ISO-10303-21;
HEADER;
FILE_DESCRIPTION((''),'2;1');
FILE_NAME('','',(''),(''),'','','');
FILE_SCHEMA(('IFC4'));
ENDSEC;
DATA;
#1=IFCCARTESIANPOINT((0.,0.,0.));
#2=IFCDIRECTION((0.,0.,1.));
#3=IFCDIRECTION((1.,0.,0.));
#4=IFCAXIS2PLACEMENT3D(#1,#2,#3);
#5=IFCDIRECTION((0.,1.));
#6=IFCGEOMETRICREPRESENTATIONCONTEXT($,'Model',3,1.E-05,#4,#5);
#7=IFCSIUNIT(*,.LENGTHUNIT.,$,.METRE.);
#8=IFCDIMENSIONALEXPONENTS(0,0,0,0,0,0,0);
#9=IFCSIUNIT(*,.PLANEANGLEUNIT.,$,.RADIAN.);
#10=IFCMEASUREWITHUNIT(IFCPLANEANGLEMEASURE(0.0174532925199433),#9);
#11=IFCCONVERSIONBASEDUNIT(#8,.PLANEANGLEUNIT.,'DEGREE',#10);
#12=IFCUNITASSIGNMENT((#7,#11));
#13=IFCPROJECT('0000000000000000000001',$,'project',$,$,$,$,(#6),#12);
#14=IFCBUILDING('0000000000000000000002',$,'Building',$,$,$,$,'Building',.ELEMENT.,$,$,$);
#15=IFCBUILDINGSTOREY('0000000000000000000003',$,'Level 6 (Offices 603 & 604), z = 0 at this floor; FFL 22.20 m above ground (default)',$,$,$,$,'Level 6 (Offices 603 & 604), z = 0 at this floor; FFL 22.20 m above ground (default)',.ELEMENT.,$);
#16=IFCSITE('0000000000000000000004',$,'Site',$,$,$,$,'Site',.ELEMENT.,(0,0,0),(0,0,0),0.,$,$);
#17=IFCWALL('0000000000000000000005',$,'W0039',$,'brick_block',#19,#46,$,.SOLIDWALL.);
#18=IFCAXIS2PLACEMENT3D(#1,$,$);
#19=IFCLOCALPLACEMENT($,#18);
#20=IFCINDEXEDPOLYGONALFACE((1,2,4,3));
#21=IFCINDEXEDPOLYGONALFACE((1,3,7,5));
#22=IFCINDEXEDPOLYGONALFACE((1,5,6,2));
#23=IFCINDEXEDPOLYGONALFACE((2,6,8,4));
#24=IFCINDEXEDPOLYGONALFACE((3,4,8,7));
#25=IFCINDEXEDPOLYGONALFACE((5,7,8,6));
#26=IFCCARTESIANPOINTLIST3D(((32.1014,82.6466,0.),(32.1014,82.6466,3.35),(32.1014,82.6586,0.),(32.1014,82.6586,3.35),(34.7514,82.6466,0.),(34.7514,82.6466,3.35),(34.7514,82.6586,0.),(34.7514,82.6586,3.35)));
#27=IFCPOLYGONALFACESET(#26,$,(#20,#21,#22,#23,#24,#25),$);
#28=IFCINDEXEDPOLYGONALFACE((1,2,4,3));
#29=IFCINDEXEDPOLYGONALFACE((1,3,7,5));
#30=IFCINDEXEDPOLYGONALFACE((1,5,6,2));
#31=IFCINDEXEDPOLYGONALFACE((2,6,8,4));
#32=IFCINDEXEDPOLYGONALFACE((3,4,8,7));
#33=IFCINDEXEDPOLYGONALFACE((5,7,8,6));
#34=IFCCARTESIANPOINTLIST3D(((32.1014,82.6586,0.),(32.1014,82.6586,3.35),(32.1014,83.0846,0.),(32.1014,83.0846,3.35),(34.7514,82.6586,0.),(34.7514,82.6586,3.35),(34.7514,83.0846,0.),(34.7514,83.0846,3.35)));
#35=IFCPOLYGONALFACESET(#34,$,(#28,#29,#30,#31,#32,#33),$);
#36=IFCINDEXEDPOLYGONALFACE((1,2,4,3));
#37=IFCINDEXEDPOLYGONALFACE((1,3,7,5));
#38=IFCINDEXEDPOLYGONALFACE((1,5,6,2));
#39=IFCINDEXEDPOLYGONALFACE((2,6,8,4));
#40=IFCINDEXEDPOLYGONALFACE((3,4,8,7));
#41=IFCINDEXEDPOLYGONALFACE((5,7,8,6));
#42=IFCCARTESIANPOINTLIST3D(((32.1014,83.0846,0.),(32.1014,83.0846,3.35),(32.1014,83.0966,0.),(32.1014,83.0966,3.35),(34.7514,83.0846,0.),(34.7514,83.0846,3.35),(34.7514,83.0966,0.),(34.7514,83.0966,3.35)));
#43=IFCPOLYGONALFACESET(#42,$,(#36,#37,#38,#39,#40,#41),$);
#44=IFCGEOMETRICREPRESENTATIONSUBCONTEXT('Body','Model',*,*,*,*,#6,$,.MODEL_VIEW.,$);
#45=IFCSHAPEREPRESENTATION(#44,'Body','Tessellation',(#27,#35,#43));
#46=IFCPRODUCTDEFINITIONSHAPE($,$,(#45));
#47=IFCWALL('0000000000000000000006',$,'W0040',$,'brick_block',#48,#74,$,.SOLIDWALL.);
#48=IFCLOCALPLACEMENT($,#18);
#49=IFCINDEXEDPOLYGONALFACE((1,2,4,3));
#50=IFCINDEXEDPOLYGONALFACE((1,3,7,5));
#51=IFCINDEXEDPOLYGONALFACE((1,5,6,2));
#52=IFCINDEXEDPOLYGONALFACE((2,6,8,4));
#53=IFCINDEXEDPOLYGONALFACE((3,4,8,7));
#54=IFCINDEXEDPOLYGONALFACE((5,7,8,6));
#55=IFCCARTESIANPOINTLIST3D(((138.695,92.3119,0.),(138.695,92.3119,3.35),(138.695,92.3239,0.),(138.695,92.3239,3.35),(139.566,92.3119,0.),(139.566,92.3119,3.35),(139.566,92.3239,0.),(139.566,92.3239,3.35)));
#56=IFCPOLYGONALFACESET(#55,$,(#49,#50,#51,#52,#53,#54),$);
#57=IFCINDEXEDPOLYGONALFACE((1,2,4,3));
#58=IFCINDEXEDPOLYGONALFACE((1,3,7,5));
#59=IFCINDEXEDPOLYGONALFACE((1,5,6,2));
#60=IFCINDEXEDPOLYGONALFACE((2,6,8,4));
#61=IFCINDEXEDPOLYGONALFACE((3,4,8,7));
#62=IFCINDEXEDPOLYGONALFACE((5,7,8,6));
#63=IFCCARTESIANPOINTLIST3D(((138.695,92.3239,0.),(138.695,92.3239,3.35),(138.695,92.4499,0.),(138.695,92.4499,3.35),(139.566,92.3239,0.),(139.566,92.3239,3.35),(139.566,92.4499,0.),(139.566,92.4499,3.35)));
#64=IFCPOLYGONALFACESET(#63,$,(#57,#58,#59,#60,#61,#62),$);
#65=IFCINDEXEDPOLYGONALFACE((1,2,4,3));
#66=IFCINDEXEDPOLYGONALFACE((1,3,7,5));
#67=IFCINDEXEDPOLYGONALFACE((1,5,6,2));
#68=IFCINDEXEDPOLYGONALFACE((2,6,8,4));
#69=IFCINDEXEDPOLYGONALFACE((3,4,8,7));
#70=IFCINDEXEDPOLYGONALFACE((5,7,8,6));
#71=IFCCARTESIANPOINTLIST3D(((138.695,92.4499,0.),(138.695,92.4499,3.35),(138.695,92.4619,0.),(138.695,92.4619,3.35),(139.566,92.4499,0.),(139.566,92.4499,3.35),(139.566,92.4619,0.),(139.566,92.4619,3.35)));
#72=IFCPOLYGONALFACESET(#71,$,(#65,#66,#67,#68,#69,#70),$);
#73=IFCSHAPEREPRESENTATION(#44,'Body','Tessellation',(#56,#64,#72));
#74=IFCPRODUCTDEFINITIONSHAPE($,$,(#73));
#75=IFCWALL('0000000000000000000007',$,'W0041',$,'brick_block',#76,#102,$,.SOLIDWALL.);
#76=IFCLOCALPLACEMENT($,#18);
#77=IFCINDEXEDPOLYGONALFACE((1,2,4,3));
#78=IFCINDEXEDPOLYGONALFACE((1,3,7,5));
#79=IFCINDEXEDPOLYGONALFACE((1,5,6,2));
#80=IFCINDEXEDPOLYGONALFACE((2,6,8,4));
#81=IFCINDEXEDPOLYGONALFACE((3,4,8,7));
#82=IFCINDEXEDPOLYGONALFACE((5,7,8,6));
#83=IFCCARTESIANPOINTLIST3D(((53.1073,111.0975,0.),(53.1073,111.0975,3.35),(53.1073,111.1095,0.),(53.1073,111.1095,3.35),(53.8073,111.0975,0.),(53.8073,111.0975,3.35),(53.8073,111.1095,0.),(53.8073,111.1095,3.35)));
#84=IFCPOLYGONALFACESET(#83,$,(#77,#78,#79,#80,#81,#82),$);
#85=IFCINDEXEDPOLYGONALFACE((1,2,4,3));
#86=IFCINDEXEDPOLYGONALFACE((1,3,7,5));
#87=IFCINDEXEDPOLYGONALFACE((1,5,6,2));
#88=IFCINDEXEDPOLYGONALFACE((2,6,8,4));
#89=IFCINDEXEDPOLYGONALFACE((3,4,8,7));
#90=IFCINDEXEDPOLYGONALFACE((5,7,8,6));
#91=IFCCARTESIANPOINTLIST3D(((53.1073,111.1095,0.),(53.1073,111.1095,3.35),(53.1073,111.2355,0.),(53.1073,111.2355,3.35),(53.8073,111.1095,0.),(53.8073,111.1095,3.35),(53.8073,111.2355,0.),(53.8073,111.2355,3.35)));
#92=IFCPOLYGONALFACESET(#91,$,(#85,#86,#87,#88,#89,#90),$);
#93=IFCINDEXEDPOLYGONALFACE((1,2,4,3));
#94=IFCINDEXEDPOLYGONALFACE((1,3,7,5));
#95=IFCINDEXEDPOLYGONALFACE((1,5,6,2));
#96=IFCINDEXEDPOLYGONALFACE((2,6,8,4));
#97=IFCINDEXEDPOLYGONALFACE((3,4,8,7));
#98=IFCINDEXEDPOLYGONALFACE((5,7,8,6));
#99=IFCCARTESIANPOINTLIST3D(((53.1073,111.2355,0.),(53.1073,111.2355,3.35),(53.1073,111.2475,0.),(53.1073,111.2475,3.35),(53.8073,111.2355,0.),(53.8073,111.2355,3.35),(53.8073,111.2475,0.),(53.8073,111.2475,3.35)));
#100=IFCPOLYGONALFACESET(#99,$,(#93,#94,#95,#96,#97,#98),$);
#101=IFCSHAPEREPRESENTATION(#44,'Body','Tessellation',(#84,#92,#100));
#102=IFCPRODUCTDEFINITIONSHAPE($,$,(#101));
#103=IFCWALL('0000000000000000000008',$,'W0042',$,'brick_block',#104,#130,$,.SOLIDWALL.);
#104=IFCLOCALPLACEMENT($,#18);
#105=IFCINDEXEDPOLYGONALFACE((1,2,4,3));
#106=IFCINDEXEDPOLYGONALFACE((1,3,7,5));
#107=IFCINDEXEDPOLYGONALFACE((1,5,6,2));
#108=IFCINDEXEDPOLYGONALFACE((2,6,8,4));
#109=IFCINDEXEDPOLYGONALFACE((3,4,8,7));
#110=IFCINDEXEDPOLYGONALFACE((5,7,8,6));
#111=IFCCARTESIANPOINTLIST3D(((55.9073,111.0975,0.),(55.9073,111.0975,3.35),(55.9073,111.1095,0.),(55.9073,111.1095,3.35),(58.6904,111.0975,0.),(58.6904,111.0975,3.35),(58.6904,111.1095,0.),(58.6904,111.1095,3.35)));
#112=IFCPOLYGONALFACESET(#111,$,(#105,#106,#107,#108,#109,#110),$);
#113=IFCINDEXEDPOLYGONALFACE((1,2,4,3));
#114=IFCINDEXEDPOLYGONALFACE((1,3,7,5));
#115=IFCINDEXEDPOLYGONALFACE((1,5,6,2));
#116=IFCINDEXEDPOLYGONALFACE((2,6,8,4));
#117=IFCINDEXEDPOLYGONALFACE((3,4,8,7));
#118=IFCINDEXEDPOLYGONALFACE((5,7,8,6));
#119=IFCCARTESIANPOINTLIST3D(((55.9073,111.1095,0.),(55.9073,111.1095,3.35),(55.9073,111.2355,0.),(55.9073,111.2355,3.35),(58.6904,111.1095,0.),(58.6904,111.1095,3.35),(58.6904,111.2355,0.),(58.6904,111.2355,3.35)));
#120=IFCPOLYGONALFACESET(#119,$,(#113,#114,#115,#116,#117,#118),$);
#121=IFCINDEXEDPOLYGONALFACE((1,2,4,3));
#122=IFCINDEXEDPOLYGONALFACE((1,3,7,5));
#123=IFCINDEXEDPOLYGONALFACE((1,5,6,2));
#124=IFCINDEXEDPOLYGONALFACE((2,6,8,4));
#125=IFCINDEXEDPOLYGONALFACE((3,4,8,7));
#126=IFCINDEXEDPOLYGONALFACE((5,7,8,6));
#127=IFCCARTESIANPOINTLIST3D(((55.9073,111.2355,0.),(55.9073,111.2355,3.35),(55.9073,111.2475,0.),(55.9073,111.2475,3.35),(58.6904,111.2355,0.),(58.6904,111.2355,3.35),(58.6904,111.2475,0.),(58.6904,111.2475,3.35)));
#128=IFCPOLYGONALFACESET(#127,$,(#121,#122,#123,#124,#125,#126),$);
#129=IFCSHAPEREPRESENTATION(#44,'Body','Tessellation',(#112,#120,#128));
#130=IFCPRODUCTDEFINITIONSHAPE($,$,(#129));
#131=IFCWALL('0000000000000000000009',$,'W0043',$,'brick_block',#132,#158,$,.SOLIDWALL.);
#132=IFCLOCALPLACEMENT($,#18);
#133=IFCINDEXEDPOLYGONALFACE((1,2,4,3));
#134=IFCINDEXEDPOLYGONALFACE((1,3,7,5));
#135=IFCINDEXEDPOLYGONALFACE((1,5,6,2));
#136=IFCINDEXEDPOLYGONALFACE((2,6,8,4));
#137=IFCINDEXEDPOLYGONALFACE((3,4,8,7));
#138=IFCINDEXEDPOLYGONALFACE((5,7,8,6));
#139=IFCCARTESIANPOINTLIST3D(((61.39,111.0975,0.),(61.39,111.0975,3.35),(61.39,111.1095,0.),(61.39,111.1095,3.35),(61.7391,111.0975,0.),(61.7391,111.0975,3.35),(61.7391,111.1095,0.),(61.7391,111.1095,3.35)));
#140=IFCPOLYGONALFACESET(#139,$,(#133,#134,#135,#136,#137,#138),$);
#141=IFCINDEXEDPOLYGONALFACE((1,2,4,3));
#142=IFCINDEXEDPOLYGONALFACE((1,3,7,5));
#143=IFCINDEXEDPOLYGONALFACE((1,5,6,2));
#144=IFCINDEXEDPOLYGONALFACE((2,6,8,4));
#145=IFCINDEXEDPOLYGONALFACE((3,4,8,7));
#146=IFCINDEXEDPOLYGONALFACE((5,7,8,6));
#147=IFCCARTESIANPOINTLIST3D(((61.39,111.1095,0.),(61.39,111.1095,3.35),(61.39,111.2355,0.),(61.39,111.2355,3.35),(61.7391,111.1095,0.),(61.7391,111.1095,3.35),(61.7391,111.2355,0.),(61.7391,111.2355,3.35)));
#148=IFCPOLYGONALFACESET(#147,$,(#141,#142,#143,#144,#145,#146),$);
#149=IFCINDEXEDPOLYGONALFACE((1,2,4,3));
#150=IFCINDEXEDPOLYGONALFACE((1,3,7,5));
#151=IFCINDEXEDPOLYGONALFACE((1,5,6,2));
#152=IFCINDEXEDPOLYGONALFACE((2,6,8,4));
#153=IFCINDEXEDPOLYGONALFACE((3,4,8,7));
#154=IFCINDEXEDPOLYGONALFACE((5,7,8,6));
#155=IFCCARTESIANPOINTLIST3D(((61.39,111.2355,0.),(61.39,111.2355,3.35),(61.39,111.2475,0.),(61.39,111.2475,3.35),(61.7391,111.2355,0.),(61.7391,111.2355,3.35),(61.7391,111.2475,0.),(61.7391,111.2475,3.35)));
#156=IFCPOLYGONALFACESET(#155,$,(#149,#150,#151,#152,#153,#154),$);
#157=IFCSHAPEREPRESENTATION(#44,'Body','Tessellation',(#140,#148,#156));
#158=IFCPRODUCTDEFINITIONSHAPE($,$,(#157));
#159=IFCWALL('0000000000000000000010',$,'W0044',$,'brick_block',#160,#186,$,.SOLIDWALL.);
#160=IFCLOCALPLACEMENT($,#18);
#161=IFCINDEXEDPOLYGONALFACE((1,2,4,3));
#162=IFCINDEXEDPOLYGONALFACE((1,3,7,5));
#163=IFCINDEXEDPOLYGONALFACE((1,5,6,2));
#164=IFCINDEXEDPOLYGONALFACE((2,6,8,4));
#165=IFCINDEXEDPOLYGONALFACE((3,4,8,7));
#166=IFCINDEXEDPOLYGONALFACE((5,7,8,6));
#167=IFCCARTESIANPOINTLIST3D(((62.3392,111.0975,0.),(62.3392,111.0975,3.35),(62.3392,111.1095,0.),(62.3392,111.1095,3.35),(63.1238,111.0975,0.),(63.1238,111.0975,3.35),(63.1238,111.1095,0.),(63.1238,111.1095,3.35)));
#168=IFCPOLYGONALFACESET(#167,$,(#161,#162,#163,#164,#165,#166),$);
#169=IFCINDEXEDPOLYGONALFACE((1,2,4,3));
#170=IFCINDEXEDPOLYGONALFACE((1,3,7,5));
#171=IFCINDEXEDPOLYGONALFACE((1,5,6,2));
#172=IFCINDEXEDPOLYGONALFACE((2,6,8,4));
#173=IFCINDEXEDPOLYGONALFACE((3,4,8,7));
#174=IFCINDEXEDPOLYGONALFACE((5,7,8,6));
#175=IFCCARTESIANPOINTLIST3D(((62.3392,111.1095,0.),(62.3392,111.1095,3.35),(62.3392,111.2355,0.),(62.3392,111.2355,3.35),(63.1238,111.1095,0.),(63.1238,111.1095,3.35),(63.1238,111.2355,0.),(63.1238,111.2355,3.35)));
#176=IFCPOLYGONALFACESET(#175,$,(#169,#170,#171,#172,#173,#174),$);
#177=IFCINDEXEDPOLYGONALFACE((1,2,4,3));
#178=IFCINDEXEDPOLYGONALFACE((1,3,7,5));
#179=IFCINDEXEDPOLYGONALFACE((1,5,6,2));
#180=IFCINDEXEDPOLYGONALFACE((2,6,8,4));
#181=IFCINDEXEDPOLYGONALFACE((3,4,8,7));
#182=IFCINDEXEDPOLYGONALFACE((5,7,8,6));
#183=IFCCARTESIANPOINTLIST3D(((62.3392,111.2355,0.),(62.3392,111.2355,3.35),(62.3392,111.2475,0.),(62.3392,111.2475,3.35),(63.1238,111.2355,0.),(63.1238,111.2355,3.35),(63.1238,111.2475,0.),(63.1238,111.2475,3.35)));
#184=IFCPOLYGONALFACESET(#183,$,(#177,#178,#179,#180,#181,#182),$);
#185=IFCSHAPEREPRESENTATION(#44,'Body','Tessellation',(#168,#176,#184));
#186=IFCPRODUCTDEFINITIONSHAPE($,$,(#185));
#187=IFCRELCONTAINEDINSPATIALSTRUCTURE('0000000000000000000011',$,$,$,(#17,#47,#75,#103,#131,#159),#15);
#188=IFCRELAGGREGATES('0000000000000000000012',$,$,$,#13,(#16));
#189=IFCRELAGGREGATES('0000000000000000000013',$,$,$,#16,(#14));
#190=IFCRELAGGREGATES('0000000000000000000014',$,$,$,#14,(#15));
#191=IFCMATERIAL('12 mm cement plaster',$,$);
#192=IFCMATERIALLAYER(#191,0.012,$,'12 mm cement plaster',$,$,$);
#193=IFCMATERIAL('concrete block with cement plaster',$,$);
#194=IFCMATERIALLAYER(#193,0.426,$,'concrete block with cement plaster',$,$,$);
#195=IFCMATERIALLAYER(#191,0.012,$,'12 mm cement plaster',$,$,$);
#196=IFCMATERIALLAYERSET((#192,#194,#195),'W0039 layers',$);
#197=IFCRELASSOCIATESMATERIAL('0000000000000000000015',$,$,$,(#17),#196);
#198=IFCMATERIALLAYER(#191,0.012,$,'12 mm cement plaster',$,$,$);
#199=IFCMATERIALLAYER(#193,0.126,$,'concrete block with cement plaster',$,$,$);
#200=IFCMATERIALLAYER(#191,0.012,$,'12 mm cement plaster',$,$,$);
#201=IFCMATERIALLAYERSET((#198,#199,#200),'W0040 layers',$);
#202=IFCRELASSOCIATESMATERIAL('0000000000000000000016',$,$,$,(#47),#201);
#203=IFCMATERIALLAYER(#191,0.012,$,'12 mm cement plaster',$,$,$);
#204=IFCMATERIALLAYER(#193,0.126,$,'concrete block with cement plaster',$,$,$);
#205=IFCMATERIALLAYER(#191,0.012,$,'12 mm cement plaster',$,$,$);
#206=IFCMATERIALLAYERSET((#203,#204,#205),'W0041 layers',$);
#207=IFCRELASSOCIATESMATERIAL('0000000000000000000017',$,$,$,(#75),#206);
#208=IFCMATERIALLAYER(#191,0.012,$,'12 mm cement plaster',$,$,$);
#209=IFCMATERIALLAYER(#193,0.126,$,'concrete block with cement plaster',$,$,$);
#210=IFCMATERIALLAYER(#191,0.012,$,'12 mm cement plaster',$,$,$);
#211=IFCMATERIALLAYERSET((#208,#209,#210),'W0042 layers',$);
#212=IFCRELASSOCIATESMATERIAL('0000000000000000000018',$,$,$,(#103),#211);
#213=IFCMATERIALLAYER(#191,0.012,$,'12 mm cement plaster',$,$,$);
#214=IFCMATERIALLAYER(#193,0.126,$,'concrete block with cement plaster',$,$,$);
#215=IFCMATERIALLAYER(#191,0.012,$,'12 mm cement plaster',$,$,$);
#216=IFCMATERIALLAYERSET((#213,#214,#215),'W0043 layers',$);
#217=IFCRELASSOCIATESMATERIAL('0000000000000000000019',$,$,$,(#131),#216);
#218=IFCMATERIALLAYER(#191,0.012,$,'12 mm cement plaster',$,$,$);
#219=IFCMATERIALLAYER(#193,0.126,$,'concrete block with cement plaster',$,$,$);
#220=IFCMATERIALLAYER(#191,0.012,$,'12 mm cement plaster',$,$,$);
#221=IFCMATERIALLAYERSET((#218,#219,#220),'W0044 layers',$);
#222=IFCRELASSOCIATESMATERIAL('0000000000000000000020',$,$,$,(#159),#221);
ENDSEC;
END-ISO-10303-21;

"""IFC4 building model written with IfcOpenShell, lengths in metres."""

from ifc_helpers import new_model, entity, si_unit, converted_unit, direction, frame, frame_2d, origin_with_axes, origin_2d_with_axis, place, context, subcontext, project, spatial, rectangle, extrude, material, layer, layer_set, layer_usage, element, save


model = new_model("IFC4")

# Units and contexts
model_context = context("Model", 3, precision=1e-05, world=origin_with_axes(), true_north=direction((0.0, 1.0)))
body_context = subcontext(model_context, "Body", "Model", "MODEL_VIEW")
ifc_project = project(units=[si_unit("LENGTHUNIT", "METRE"), converted_unit("PLANEANGLEUNIT", "DEGREE", entity("IfcPlaneAngleMeasure", 0.0174532925199433), si_unit("PLANEANGLEUNIT", "RADIAN"), dimensions=[0, 0, 0, 0, 0, 0, 0])], contexts=[model_context])

# Site, building, storey
site = spatial("IfcSite", under=ifc_project, Name="Site", LongName="Site", CompositionType="ELEMENT", RefLatitude=(0, 0, 0), RefLongitude=(0, 0, 0), RefElevation=0.0)
building = spatial("IfcBuilding", under=site, Name="Building", LongName="Building", CompositionType="ELEMENT")
storey = spatial("IfcBuildingStorey", under=building, Name="Level 6 (Offices 603 & 604), z = 0 at this floor; FFL 22.20 m above ground (default)", LongName="Level 6 (Offices 603 & 604), z = 0 at this floor; FFL 22.20 m above ground (default)", CompositionType="ELEMENT")

# Shared definitions
ifc_material_1 = material(Name="12 mm cement plaster")
ifc_material_2 = material(Name="concrete block with cement plaster")
placement = place(None, origin_with_axes())

# Walls
ifc_layer_1 = layer(ifc_material_1, 0.012, Name="12 mm cement plaster")
ifc_layer_2 = layer(ifc_material_2, 0.426, Name="concrete block with cement plaster")
ifc_layer_3 = layer(ifc_material_1, 0.012, Name="12 mm cement plaster")
ifc_layer_set_1 = layer_set([ifc_layer_1, ifc_layer_2, ifc_layer_3], Name="W0039 layers")
ifc_layer_usage_1 = layer_usage(ifc_layer_set_1, "AXIS2", "POSITIVE", -0.225)
element("IfcWall", 1, at=placement, inside=storey, material=ifc_layer_usage_1, Name="W0039", ObjectType="brick_block", PredefinedType="SOLIDWALL", context=body_context, shape_type="SweptSolid", body=[
    extrude(rectangle(XDim=2.65, YDim=0.012, at=origin_2d_with_axis()), frame((33.4264, 82.6526, 0.0), z_axis=(0.0, 0.0, 1.0), x_axis=(1.0, 0.0, 0.0)), (0.0, 0.0, 1.0), 3.35),
    extrude(rectangle(XDim=2.65, YDim=0.426, at=frame_2d((0.0, 0.219), x_axis=(1.0, 0.0))), frame((33.4264, 82.6526, 0.0), z_axis=(0.0, 0.0, 1.0), x_axis=(1.0, 0.0, 0.0)), (0.0, 0.0, 1.0), 3.35),
    extrude(rectangle(XDim=2.65, YDim=0.012, at=frame_2d((0.0, 0.438), x_axis=(1.0, 0.0))), frame((33.4264, 82.6526, 0.0), z_axis=(0.0, 0.0, 1.0), x_axis=(1.0, 0.0, 0.0)), (0.0, 0.0, 1.0), 3.35),
])
ifc_layer_4 = layer(ifc_material_1, 0.012, Name="12 mm cement plaster")
ifc_layer_5 = layer(ifc_material_2, 0.126, Name="concrete block with cement plaster")
ifc_layer_6 = layer(ifc_material_1, 0.012, Name="12 mm cement plaster")
ifc_layer_set_2 = layer_set([ifc_layer_4, ifc_layer_5, ifc_layer_6], Name="W0040 layers")
ifc_layer_usage_2 = layer_usage(ifc_layer_set_2, "AXIS2", "POSITIVE", -0.075)
element("IfcWall", 2, at=placement, inside=storey, material=ifc_layer_usage_2, Name="W0040", ObjectType="brick_block", PredefinedType="SOLIDWALL", context=body_context, shape_type="SweptSolid", body=[
    extrude(rectangle(XDim=0.871, YDim=0.012, at=frame_2d((0.0, 0.0), x_axis=(1.0, 0.0))), frame((139.1305, 92.3179, 0.0), z_axis=(0.0, 0.0, 1.0), x_axis=(1.0, 0.0, 0.0)), (0.0, 0.0, 1.0), 3.35),
    extrude(rectangle(XDim=0.871, YDim=0.126, at=frame_2d((0.0, 0.069), x_axis=(1.0, 0.0))), frame((139.1305, 92.3179, 0.0), z_axis=(0.0, 0.0, 1.0), x_axis=(1.0, 0.0, 0.0)), (0.0, 0.0, 1.0), 3.35),
    extrude(rectangle(XDim=0.871, YDim=0.012, at=frame_2d((0.0, 0.138), x_axis=(1.0, 0.0))), frame((139.1305, 92.3179, 0.0), z_axis=(0.0, 0.0, 1.0), x_axis=(1.0, 0.0, 0.0)), (0.0, 0.0, 1.0), 3.35),
])
ifc_layer_7 = layer(ifc_material_1, 0.012, Name="12 mm cement plaster")
ifc_layer_8 = layer(ifc_material_2, 0.126, Name="concrete block with cement plaster")
ifc_layer_9 = layer(ifc_material_1, 0.012, Name="12 mm cement plaster")
ifc_layer_set_3 = layer_set([ifc_layer_7, ifc_layer_8, ifc_layer_9], Name="W0041 layers")
ifc_layer_usage_3 = layer_usage(ifc_layer_set_3, "AXIS2", "POSITIVE", -0.075)
element("IfcWall", 3, at=placement, inside=storey, material=ifc_layer_usage_3, Name="W0041", ObjectType="brick_block", PredefinedType="SOLIDWALL", context=body_context, shape_type="SweptSolid", body=[
    extrude(rectangle(XDim=0.7, YDim=0.012, at=origin_2d_with_axis()), frame((53.4573, 111.1035, 0.0), z_axis=(0.0, 0.0, 1.0), x_axis=(1.0, 0.0, 0.0)), (0.0, 0.0, 1.0), 3.35),
    extrude(rectangle(XDim=0.7, YDim=0.126, at=frame_2d((0.0, 0.069), x_axis=(1.0, 0.0))), frame((53.4573, 111.1035, 0.0), z_axis=(0.0, 0.0, 1.0), x_axis=(1.0, 0.0, 0.0)), (0.0, 0.0, 1.0), 3.35),
    extrude(rectangle(XDim=0.7, YDim=0.012, at=frame_2d((0.0, 0.138), x_axis=(1.0, 0.0))), frame((53.4573, 111.1035, 0.0), z_axis=(0.0, 0.0, 1.0), x_axis=(1.0, 0.0, 0.0)), (0.0, 0.0, 1.0), 3.35),
])
ifc_layer_10 = layer(ifc_material_1, 0.012, Name="12 mm cement plaster")
ifc_layer_11 = layer(ifc_material_2, 0.126, Name="concrete block with cement plaster")
ifc_layer_12 = layer(ifc_material_1, 0.012, Name="12 mm cement plaster")
ifc_layer_set_4 = layer_set([ifc_layer_10, ifc_layer_11, ifc_layer_12], Name="W0042 layers")
ifc_layer_usage_4 = layer_usage(ifc_layer_set_4, "AXIS2", "POSITIVE", -0.075)
element("IfcWall", 4, at=placement, inside=storey, material=ifc_layer_usage_4, Name="W0042", ObjectType="brick_block", PredefinedType="SOLIDWALL", context=body_context, shape_type="SweptSolid", body=[
    extrude(rectangle(XDim=2.7831, YDim=0.012, at=origin_2d_with_axis()), frame((57.2989, 111.1035, 0.0), z_axis=(0.0, 0.0, 1.0), x_axis=(1.0, 0.0, 0.0)), (0.0, 0.0, 1.0), 3.35),
    extrude(rectangle(XDim=2.7831, YDim=0.126, at=frame_2d((0.0, 0.069), x_axis=(1.0, 0.0))), frame((57.2989, 111.1035, 0.0), z_axis=(0.0, 0.0, 1.0), x_axis=(1.0, 0.0, 0.0)), (0.0, 0.0, 1.0), 3.35),
    extrude(rectangle(XDim=2.7831, YDim=0.012, at=frame_2d((0.0, 0.138), x_axis=(1.0, 0.0))), frame((57.2989, 111.1035, 0.0), z_axis=(0.0, 0.0, 1.0), x_axis=(1.0, 0.0, 0.0)), (0.0, 0.0, 1.0), 3.35),
])
ifc_layer_13 = layer(ifc_material_1, 0.012, Name="12 mm cement plaster")
ifc_layer_14 = layer(ifc_material_2, 0.126, Name="concrete block with cement plaster")
ifc_layer_15 = layer(ifc_material_1, 0.012, Name="12 mm cement plaster")
ifc_layer_set_5 = layer_set([ifc_layer_13, ifc_layer_14, ifc_layer_15], Name="W0043 layers")
ifc_layer_usage_5 = layer_usage(ifc_layer_set_5, "AXIS2", "POSITIVE", -0.075)
element("IfcWall", 5, at=placement, inside=storey, material=ifc_layer_usage_5, Name="W0043", ObjectType="brick_block", PredefinedType="SOLIDWALL", context=body_context, shape_type="SweptSolid", body=[
    extrude(rectangle(XDim=0.3491, YDim=0.012, at=origin_2d_with_axis()), frame((61.5645, 111.1035, 0.0), z_axis=(0.0, 0.0, 1.0), x_axis=(1.0, 0.0, 0.0)), (0.0, 0.0, 1.0), 3.35),
    extrude(rectangle(XDim=0.3491, YDim=0.126, at=frame_2d((0.0, 0.069), x_axis=(1.0, 0.0))), frame((61.5645, 111.1035, 0.0), z_axis=(0.0, 0.0, 1.0), x_axis=(1.0, 0.0, 0.0)), (0.0, 0.0, 1.0), 3.35),
    extrude(rectangle(XDim=0.3491, YDim=0.012, at=frame_2d((0.0, 0.138), x_axis=(1.0, 0.0))), frame((61.5645, 111.1035, 0.0), z_axis=(0.0, 0.0, 1.0), x_axis=(1.0, 0.0, 0.0)), (0.0, 0.0, 1.0), 3.35),
])
ifc_layer_16 = layer(ifc_material_1, 0.012, Name="12 mm cement plaster")
ifc_layer_17 = layer(ifc_material_2, 0.126, Name="concrete block with cement plaster")
ifc_layer_18 = layer(ifc_material_1, 0.012, Name="12 mm cement plaster")
ifc_layer_set_6 = layer_set([ifc_layer_16, ifc_layer_17, ifc_layer_18], Name="W0044 layers")
ifc_layer_usage_6 = layer_usage(ifc_layer_set_6, "AXIS2", "POSITIVE", -0.075)
element("IfcWall", 6, at=placement, inside=storey, material=ifc_layer_usage_6, Name="W0044", ObjectType="brick_block", PredefinedType="SOLIDWALL", context=body_context, shape_type="SweptSolid", body=[
    extrude(rectangle(XDim=0.7846, YDim=0.012, at=origin_2d_with_axis()), frame((62.7315, 111.1035, 0.0), z_axis=(0.0, 0.0, 1.0), x_axis=(1.0, 0.0, 0.0)), (0.0, 0.0, 1.0), 3.35),
    extrude(rectangle(XDim=0.7846, YDim=0.126, at=frame_2d((0.0, 0.069), x_axis=(1.0, 0.0))), frame((62.7315, 111.1035, 0.0), z_axis=(0.0, 0.0, 1.0), x_axis=(1.0, 0.0, 0.0)), (0.0, 0.0, 1.0), 3.35),
    extrude(rectangle(XDim=0.7846, YDim=0.012, at=frame_2d((0.0, 0.138), x_axis=(1.0, 0.0))), frame((62.7315, 111.1035, 0.0), z_axis=(0.0, 0.0, 1.0), x_axis=(1.0, 0.0, 0.0)), (0.0, 0.0, 1.0), 3.35),
])

save(model, "model.ifc")
